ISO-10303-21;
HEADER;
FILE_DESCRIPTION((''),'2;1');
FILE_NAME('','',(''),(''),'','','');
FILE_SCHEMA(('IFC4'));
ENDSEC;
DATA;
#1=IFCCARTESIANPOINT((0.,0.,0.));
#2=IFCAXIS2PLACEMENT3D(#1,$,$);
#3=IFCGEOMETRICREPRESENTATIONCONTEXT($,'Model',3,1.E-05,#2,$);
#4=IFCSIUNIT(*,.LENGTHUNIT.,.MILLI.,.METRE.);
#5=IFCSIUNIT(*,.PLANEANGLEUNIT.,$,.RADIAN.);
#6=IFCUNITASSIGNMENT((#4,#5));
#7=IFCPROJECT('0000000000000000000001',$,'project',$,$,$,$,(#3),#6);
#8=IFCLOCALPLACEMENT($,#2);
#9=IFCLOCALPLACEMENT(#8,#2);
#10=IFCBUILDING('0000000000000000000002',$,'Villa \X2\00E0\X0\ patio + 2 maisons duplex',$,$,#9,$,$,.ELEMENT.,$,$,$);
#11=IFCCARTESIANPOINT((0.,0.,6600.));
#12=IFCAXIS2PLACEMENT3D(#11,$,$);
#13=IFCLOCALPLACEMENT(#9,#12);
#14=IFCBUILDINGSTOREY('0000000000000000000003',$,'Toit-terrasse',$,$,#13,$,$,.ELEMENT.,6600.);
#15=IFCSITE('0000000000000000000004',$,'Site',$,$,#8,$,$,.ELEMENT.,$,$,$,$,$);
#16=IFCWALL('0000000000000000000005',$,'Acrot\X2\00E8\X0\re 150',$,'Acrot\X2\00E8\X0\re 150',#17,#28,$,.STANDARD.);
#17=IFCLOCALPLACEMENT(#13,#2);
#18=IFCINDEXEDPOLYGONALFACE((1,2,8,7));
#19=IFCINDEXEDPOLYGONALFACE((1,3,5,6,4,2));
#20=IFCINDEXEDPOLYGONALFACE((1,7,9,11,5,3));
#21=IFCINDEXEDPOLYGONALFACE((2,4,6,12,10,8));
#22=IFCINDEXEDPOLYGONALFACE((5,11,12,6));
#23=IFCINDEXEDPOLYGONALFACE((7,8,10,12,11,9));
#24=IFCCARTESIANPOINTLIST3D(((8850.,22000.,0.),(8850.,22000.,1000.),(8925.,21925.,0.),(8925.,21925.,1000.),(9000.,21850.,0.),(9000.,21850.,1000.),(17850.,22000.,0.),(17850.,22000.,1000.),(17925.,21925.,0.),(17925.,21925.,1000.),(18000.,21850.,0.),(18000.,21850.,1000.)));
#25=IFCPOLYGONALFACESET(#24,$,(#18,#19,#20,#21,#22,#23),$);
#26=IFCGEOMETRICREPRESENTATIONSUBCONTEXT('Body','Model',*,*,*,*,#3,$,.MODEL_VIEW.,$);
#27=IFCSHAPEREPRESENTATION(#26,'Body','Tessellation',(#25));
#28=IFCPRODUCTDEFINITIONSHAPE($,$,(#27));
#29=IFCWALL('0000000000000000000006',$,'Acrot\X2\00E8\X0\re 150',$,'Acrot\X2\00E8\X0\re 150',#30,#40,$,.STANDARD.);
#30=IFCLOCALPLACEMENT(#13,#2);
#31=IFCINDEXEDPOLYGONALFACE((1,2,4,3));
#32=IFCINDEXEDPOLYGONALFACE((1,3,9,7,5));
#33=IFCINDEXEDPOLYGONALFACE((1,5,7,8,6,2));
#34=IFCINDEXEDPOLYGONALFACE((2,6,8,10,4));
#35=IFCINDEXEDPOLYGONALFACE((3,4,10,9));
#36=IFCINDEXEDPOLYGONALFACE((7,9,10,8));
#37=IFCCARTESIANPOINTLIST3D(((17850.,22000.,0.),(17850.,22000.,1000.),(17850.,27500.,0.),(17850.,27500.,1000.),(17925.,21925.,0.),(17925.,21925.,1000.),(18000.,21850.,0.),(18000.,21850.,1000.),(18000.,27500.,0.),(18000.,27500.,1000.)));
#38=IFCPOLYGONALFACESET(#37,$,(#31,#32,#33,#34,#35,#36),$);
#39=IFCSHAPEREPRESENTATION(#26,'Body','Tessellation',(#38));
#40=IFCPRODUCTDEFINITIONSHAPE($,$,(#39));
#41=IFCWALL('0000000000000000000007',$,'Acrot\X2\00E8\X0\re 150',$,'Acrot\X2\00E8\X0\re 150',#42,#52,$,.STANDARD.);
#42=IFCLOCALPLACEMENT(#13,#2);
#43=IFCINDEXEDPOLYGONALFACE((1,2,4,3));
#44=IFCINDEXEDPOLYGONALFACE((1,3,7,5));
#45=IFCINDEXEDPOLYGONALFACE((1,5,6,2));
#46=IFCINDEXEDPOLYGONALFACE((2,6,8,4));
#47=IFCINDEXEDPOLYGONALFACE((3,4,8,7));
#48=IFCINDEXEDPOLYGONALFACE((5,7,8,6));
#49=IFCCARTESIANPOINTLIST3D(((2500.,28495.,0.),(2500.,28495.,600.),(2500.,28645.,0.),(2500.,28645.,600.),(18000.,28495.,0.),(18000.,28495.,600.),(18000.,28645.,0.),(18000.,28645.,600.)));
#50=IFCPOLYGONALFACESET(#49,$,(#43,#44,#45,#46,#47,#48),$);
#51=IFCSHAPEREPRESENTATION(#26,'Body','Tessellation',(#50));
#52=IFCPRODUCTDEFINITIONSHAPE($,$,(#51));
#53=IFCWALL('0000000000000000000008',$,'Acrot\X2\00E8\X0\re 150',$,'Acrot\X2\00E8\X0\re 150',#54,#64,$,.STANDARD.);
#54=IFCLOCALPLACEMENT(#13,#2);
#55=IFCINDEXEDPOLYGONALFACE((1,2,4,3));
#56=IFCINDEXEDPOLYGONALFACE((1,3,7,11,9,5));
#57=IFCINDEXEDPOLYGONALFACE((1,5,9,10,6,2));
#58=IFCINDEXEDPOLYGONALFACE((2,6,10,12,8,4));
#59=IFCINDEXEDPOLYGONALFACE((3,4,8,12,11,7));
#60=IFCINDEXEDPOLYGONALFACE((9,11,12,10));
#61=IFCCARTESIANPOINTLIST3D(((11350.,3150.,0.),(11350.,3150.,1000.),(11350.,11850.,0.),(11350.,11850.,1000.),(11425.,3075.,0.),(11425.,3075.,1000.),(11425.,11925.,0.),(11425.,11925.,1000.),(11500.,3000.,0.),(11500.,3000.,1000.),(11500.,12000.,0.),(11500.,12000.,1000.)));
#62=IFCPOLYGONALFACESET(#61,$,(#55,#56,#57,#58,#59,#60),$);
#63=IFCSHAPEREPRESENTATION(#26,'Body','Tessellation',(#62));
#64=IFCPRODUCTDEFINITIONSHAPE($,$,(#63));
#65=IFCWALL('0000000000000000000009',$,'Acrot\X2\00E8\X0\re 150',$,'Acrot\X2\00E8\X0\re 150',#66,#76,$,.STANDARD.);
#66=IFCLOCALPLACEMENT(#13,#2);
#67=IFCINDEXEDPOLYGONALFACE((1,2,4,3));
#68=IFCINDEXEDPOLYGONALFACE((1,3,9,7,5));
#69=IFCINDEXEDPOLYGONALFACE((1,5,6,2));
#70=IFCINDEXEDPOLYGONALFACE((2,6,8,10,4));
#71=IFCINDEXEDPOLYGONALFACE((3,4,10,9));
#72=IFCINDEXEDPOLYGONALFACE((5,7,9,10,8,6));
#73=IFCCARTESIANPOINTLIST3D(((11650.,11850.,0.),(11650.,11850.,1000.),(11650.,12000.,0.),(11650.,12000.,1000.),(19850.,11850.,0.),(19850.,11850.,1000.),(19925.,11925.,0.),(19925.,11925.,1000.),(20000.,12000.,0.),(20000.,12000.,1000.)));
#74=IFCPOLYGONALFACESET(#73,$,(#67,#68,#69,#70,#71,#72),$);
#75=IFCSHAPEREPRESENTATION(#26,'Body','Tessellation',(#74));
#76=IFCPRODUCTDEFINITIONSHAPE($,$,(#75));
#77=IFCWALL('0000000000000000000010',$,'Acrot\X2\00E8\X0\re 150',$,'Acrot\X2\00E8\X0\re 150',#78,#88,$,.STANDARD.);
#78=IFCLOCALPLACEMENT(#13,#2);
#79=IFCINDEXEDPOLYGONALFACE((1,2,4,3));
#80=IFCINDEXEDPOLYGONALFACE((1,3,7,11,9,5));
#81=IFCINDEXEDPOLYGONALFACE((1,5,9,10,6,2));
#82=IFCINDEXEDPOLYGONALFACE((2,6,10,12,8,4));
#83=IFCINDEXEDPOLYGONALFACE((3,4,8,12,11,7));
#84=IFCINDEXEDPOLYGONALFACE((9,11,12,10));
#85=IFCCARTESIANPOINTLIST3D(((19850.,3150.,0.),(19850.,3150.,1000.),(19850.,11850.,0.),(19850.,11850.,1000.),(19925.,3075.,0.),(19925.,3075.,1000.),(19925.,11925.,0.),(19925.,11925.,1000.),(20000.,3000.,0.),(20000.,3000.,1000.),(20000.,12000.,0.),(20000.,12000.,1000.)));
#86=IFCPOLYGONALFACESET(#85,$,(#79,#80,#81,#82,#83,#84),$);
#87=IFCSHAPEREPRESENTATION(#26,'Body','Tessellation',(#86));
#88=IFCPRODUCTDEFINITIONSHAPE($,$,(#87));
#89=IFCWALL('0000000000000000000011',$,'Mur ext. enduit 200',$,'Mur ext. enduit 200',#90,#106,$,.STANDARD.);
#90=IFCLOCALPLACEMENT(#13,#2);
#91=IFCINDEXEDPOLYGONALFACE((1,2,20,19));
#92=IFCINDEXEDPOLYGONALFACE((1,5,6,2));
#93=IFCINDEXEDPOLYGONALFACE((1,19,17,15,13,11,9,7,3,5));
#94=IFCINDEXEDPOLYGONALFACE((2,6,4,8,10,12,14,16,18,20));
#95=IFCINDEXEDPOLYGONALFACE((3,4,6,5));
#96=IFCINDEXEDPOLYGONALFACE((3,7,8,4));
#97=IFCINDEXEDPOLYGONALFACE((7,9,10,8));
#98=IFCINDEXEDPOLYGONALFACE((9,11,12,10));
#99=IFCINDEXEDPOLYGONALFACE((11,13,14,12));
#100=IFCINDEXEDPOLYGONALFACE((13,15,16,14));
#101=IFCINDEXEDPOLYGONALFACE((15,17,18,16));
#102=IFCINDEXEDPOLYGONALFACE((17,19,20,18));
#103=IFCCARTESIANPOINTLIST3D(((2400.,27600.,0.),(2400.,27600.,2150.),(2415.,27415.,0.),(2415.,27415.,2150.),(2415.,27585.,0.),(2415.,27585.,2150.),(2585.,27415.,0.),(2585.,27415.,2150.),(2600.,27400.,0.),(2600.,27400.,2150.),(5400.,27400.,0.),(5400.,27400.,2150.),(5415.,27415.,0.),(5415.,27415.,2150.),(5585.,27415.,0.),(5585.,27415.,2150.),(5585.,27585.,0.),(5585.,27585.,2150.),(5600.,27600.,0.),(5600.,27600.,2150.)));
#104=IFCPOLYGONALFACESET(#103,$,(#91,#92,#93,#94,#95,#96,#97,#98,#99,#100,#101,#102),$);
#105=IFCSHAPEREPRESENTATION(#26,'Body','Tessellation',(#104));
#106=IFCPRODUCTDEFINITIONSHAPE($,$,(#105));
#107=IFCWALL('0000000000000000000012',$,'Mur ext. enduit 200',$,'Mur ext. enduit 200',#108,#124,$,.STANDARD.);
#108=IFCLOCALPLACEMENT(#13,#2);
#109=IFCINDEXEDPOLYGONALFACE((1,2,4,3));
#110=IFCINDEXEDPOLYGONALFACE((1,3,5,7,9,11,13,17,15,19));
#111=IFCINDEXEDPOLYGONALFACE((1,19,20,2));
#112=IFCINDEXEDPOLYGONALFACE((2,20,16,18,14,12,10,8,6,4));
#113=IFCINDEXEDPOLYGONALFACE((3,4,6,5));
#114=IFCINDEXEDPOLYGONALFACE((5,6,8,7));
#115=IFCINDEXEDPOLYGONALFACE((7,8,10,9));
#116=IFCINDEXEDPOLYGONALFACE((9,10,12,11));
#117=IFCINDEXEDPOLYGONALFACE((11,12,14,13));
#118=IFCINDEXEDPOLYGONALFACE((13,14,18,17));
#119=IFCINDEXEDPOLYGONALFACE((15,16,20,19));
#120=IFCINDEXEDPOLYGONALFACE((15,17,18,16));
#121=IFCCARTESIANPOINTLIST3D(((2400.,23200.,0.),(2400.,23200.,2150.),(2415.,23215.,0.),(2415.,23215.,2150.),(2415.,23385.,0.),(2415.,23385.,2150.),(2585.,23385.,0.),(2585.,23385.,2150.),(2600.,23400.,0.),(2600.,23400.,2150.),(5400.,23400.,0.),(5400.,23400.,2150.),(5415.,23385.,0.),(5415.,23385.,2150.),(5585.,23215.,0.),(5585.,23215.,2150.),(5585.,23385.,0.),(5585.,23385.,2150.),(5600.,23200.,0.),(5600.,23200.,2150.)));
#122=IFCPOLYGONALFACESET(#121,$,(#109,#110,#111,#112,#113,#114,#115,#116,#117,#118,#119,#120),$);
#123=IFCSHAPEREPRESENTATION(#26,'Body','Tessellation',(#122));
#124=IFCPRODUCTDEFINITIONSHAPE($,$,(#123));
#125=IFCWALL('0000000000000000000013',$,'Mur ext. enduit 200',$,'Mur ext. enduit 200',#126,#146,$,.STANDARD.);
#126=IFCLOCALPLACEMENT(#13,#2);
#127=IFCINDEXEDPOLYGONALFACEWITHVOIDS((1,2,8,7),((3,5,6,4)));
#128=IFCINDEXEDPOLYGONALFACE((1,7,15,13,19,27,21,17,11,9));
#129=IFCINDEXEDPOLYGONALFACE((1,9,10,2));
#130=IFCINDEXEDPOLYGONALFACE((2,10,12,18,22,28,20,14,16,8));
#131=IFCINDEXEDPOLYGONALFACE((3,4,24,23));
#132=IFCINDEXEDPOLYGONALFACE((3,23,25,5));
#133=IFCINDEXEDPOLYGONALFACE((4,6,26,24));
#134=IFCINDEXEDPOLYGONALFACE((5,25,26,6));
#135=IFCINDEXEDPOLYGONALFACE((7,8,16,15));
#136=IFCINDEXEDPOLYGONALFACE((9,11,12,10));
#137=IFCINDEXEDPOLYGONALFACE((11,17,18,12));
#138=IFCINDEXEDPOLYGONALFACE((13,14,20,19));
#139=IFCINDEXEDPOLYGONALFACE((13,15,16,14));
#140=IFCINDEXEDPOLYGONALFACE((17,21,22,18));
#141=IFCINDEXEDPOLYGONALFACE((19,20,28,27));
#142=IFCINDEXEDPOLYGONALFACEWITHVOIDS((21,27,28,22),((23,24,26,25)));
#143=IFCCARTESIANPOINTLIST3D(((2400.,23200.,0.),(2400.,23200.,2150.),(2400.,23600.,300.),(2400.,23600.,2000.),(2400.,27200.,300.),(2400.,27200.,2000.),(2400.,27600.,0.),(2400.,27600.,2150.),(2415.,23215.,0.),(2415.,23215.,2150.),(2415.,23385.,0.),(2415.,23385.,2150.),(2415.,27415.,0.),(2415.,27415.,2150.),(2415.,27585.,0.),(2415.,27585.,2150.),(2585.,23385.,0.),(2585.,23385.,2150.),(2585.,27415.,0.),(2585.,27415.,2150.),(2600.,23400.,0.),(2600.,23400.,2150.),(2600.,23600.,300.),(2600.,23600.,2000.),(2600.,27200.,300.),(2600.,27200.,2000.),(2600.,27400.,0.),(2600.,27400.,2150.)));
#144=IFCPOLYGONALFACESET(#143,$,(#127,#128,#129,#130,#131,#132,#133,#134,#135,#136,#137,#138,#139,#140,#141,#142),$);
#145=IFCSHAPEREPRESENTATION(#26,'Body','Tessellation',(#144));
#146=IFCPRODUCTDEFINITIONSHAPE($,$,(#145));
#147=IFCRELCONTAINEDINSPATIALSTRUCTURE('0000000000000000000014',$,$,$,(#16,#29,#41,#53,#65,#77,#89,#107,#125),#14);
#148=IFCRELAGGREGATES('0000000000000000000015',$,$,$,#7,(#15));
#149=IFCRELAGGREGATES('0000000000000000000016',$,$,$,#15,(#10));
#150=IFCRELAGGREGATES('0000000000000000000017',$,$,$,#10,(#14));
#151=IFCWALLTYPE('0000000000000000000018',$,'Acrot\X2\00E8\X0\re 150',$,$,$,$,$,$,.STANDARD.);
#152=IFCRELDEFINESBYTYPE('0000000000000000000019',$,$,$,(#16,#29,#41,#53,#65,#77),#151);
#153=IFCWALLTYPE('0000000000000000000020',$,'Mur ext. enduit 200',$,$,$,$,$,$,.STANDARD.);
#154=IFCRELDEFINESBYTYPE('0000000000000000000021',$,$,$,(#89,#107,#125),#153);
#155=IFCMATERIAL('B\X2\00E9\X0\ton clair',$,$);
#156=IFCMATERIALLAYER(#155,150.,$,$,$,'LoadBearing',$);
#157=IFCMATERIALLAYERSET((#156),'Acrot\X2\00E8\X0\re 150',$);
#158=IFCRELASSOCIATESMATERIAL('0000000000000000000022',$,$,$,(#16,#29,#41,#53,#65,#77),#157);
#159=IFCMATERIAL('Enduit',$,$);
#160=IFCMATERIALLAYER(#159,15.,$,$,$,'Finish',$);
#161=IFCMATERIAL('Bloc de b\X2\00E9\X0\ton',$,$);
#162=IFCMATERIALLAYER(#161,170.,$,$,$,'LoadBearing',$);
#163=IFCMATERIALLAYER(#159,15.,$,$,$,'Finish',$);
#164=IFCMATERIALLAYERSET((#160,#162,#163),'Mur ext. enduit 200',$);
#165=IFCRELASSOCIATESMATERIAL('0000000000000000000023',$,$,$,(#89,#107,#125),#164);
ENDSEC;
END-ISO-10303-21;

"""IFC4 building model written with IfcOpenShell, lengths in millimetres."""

from ifc_helpers import new_model, si_unit, frame, frame_2d, origin, place, context, subcontext, project, spatial, polyline, rectangle, outline, extrude, material, layer, layer_set, layer_usage, type_object, element, save


model = new_model("IFC4")

# Units and contexts
model_context = context("Model", 3, precision=1e-05, world=origin())
body_context = subcontext(model_context, "Body", "Model", "MODEL_VIEW")
ifc_project = project(units=[si_unit("LENGTHUNIT", "METRE", prefix="MILLI"), si_unit("PLANEANGLEUNIT", "RADIAN")], contexts=[model_context])

# Site, building, storey
site_placement = place(None, origin())
site = spatial("IfcSite", under=ifc_project, at=site_placement, Name="Site", CompositionType="ELEMENT")
building_placement = place(site_placement, origin())
building = spatial("IfcBuilding", under=site, at=building_placement, Name="Villa à patio + 2 maisons duplex", CompositionType="ELEMENT")
storey_placement = place(building_placement, frame((0.0, 0.0, 6600.0)))
storey = spatial("IfcBuildingStorey", under=building, at=storey_placement, Name="Toit-terrasse", CompositionType="ELEMENT", Elevation=6600.0)

# Walls
ifc_material_1 = material(Name="Béton clair")
ifc_layer_1 = layer(ifc_material_1, 150.0, Category="LoadBearing")
ifc_layer_set_1 = layer_set([ifc_layer_1], Name="Acrotère 150")
ifc_layer_usage_1 = layer_usage(ifc_layer_set_1, "AXIS2", "NEGATIVE", 75.0)
wall_type_1 = type_object("IfcWallType", Name="Acrotère 150", PredefinedType="STANDARD")
wall_1_placement = place(storey_placement, frame((8925.0, 21925.0, 0.0), z_axis=(0.0, 0.0, 1.0), x_axis=(1.0, 0.0, 0.0)))
element("IfcWall", 1, at=wall_1_placement, inside=storey, type_object=wall_type_1, material=ifc_layer_usage_1, Name="Acrotère 150", ObjectType="Acrotère 150", PredefinedType="STANDARD", context=body_context, shape_type="SweptSolid", body=[
    extrude(outline(polyline([(75.0, -75.0), (0.0, 0.0), (-75.0, 75.0), (8925.0, 75.0), (9000.0, 0.0), (9075.0, -75.0), (75.0, -75.0)])), origin(), (0.0, 0.0, 1.0), 1000.0),
])
wall_2_placement = place(storey_placement, frame((17925.0, 21925.0, 0.0), z_axis=(0.0, 0.0, 1.0), x_axis=(0.0, 1.0, 0.0)))
element("IfcWall", 2, at=wall_2_placement, inside=storey, type_object=wall_type_1, material=ifc_layer_usage_1, Name="Acrotère 150", ObjectType="Acrotère 150", PredefinedType="STANDARD", context=body_context, shape_type="SweptSolid", body=[
    extrude(outline(polyline([(-75.0, -75.0), (0.0, 0.0), (75.0, 75.0), (5575.0, 75.0), (5575.0, -75.0), (-75.0, -75.0)])), origin(), (0.0, 0.0, 1.0), 1000.0),
])
wall_3_placement = place(storey_placement, frame((2500.0, 28570.0, 0.0), z_axis=(0.0, 0.0, 1.0), x_axis=(1.0, 0.0, 0.0)))
element("IfcWall", 3, at=wall_3_placement, inside=storey, type_object=wall_type_1, material=ifc_layer_usage_1, Name="Acrotère 150", ObjectType="Acrotère 150", PredefinedType="STANDARD", context=body_context, shape_type="SweptSolid", body=[
    extrude(outline(polyline([(0.0, -75.0), (0.0, 75.0), (15500.0, 75.0), (15500.0, -75.0), (0.0, -75.0)])), origin(), (0.0, 0.0, 1.0), 600.0),
])
wall_4_placement = place(storey_placement, frame((11425.0, 11925.0, 0.0), z_axis=(0.0, 0.0, 1.0), x_axis=(0.0, -1.0, 0.0)))
element("IfcWall", 4, at=wall_4_placement, inside=storey, type_object=wall_type_1, material=ifc_layer_usage_1, Name="Acrotère 150", ObjectType="Acrotère 150", PredefinedType="STANDARD", context=body_context, shape_type="SweptSolid", body=[
    extrude(outline(polyline([(75.0, -75.0), (0.0, 0.0), (-75.0, 75.0), (8925.0, 75.0), (8850.0, 0.0), (8775.0, -75.0), (75.0, -75.0)])), origin(), (0.0, 0.0, 1.0), 1000.0),
])
wall_5_placement = place(storey_placement, frame((11650.0, 11925.0, 0.0), z_axis=(0.0, 0.0, 1.0), x_axis=(1.0, 0.0, 0.0)))
element("IfcWall", 5, at=wall_5_placement, inside=storey, type_object=wall_type_1, material=ifc_layer_usage_1, Name="Acrotère 150", ObjectType="Acrotère 150", PredefinedType="STANDARD", context=body_context, shape_type="SweptSolid", body=[
    extrude(outline(polyline([(0.0, -75.0), (0.0, 75.0), (8350.0, 75.0), (8275.0, 0.0), (8200.0, -75.0), (0.0, -75.0)])), origin(), (0.0, 0.0, 1.0), 1000.0),
])
wall_6_placement = place(storey_placement, frame((19925.0, 11925.0, 0.0), z_axis=(0.0, 0.0, 1.0), x_axis=(0.0, -1.0, 0.0)))
element("IfcWall", 6, at=wall_6_placement, inside=storey, type_object=wall_type_1, material=ifc_layer_usage_1, Name="Acrotère 150", ObjectType="Acrotère 150", PredefinedType="STANDARD", context=body_context, shape_type="SweptSolid", body=[
    extrude(outline(polyline([(75.0, -75.0), (0.0, 0.0), (-75.0, 75.0), (8925.0, 75.0), (8850.0, 0.0), (8775.0, -75.0), (75.0, -75.0)])), origin(), (0.0, 0.0, 1.0), 1000.0),
])
ifc_material_2 = material(Name="Enduit")
ifc_layer_2 = layer(ifc_material_2, 15.0, Category="Finish")
ifc_material_3 = material(Name="Bloc de béton")
ifc_layer_3 = layer(ifc_material_3, 170.0, Category="LoadBearing")
ifc_layer_4 = layer(ifc_material_2, 15.0, Category="Finish")
ifc_layer_set_2 = layer_set([ifc_layer_2, ifc_layer_3, ifc_layer_4], Name="Mur ext. enduit 200")
ifc_layer_usage_2 = layer_usage(ifc_layer_set_2, "AXIS2", "NEGATIVE", 100.0)
wall_type_2 = type_object("IfcWallType", Name="Mur ext. enduit 200", PredefinedType="STANDARD")
wall_7_placement = place(storey_placement, frame((2500.0, 27500.0, 0.0), z_axis=(0.0, 0.0, 1.0), x_axis=(1.0, 0.0, 0.0)))
element("IfcWall", 7, at=wall_7_placement, inside=storey, type_object=wall_type_2, material=ifc_layer_usage_2, Name="Mur ext. enduit 200", ObjectType="Mur ext. enduit 200", PredefinedType="STANDARD", context=body_context, shape_type="SweptSolid", body=[
    extrude(outline(polyline([(100.0, -100.0), (85.0, -85.0), (-85.0, -85.0), (-85.0, 85.0), (-100.0, 100.0), (3100.0, 100.0), (3085.0, 85.0), (3085.0, -85.0), (2915.0, -85.0), (2900.0, -100.0), (100.0, -100.0)])), origin(), (0.0, 0.0, 1.0), 2150.0),
])
wall_8_placement = place(storey_placement, frame((2500.0, 23300.0, 0.0), z_axis=(0.0, 0.0, 1.0), x_axis=(1.0, 0.0, 0.0)))
element("IfcWall", 8, at=wall_8_placement, inside=storey, type_object=wall_type_2, material=ifc_layer_usage_2, Name="Mur ext. enduit 200", ObjectType="Mur ext. enduit 200", PredefinedType="STANDARD", context=body_context, shape_type="SweptSolid", body=[
    extrude(outline(polyline([(-100.0, -100.0), (-85.0, -85.0), (-85.0, 85.0), (85.0, 85.0), (100.0, 100.0), (2900.0, 100.0), (2915.0, 85.0), (3085.0, 85.0), (3085.0, -85.0), (3100.0, -100.0), (-100.0, -100.0)])), origin(), (0.0, 0.0, 1.0), 2150.0),
])

# Wall, opening
wall_9_placement = place(storey_placement, frame((2500.0, 27500.0, 0.0), z_axis=(0.0, 0.0, 1.0), x_axis=(0.0, -1.0, 0.0)))
wall_9 = element("IfcWall", 9, at=wall_9_placement, inside=storey, type_object=wall_type_2, material=ifc_layer_usage_2, Name="Mur ext. enduit 200", ObjectType="Mur ext. enduit 200", PredefinedType="STANDARD", context=body_context, shape_type="SweptSolid", body=[
    extrude(outline(polyline([(-100.0, -100.0), (-85.0, -85.0), (85.0, -85.0), (85.0, 85.0), (100.0, 100.0), (4100.0, 100.0), (4115.0, 85.0), (4115.0, -85.0), (4285.0, -85.0), (4300.0, -100.0), (-100.0, -100.0)])), origin(), (0.0, 0.0, 1.0), 2150.0),
])
opening_1_placement = place(wall_9_placement, frame((300.0, 0.0, 300.0), z_axis=(0.0, 0.0, 1.0), x_axis=(1.0, 0.0, 0.0)))
element("IfcOpeningElement", 10, at=opening_1_placement, cuts=wall_9, PredefinedType="OPENING", context=body_context, shape_type="SweptSolid", body=[
    extrude(rectangle(XDim=3600.0, YDim=220.0, at=frame_2d((1800.0, 0.0))), origin(), (0.0, 0.0, 1.0), 1700.0),
])

save(model, "model.ifc")
